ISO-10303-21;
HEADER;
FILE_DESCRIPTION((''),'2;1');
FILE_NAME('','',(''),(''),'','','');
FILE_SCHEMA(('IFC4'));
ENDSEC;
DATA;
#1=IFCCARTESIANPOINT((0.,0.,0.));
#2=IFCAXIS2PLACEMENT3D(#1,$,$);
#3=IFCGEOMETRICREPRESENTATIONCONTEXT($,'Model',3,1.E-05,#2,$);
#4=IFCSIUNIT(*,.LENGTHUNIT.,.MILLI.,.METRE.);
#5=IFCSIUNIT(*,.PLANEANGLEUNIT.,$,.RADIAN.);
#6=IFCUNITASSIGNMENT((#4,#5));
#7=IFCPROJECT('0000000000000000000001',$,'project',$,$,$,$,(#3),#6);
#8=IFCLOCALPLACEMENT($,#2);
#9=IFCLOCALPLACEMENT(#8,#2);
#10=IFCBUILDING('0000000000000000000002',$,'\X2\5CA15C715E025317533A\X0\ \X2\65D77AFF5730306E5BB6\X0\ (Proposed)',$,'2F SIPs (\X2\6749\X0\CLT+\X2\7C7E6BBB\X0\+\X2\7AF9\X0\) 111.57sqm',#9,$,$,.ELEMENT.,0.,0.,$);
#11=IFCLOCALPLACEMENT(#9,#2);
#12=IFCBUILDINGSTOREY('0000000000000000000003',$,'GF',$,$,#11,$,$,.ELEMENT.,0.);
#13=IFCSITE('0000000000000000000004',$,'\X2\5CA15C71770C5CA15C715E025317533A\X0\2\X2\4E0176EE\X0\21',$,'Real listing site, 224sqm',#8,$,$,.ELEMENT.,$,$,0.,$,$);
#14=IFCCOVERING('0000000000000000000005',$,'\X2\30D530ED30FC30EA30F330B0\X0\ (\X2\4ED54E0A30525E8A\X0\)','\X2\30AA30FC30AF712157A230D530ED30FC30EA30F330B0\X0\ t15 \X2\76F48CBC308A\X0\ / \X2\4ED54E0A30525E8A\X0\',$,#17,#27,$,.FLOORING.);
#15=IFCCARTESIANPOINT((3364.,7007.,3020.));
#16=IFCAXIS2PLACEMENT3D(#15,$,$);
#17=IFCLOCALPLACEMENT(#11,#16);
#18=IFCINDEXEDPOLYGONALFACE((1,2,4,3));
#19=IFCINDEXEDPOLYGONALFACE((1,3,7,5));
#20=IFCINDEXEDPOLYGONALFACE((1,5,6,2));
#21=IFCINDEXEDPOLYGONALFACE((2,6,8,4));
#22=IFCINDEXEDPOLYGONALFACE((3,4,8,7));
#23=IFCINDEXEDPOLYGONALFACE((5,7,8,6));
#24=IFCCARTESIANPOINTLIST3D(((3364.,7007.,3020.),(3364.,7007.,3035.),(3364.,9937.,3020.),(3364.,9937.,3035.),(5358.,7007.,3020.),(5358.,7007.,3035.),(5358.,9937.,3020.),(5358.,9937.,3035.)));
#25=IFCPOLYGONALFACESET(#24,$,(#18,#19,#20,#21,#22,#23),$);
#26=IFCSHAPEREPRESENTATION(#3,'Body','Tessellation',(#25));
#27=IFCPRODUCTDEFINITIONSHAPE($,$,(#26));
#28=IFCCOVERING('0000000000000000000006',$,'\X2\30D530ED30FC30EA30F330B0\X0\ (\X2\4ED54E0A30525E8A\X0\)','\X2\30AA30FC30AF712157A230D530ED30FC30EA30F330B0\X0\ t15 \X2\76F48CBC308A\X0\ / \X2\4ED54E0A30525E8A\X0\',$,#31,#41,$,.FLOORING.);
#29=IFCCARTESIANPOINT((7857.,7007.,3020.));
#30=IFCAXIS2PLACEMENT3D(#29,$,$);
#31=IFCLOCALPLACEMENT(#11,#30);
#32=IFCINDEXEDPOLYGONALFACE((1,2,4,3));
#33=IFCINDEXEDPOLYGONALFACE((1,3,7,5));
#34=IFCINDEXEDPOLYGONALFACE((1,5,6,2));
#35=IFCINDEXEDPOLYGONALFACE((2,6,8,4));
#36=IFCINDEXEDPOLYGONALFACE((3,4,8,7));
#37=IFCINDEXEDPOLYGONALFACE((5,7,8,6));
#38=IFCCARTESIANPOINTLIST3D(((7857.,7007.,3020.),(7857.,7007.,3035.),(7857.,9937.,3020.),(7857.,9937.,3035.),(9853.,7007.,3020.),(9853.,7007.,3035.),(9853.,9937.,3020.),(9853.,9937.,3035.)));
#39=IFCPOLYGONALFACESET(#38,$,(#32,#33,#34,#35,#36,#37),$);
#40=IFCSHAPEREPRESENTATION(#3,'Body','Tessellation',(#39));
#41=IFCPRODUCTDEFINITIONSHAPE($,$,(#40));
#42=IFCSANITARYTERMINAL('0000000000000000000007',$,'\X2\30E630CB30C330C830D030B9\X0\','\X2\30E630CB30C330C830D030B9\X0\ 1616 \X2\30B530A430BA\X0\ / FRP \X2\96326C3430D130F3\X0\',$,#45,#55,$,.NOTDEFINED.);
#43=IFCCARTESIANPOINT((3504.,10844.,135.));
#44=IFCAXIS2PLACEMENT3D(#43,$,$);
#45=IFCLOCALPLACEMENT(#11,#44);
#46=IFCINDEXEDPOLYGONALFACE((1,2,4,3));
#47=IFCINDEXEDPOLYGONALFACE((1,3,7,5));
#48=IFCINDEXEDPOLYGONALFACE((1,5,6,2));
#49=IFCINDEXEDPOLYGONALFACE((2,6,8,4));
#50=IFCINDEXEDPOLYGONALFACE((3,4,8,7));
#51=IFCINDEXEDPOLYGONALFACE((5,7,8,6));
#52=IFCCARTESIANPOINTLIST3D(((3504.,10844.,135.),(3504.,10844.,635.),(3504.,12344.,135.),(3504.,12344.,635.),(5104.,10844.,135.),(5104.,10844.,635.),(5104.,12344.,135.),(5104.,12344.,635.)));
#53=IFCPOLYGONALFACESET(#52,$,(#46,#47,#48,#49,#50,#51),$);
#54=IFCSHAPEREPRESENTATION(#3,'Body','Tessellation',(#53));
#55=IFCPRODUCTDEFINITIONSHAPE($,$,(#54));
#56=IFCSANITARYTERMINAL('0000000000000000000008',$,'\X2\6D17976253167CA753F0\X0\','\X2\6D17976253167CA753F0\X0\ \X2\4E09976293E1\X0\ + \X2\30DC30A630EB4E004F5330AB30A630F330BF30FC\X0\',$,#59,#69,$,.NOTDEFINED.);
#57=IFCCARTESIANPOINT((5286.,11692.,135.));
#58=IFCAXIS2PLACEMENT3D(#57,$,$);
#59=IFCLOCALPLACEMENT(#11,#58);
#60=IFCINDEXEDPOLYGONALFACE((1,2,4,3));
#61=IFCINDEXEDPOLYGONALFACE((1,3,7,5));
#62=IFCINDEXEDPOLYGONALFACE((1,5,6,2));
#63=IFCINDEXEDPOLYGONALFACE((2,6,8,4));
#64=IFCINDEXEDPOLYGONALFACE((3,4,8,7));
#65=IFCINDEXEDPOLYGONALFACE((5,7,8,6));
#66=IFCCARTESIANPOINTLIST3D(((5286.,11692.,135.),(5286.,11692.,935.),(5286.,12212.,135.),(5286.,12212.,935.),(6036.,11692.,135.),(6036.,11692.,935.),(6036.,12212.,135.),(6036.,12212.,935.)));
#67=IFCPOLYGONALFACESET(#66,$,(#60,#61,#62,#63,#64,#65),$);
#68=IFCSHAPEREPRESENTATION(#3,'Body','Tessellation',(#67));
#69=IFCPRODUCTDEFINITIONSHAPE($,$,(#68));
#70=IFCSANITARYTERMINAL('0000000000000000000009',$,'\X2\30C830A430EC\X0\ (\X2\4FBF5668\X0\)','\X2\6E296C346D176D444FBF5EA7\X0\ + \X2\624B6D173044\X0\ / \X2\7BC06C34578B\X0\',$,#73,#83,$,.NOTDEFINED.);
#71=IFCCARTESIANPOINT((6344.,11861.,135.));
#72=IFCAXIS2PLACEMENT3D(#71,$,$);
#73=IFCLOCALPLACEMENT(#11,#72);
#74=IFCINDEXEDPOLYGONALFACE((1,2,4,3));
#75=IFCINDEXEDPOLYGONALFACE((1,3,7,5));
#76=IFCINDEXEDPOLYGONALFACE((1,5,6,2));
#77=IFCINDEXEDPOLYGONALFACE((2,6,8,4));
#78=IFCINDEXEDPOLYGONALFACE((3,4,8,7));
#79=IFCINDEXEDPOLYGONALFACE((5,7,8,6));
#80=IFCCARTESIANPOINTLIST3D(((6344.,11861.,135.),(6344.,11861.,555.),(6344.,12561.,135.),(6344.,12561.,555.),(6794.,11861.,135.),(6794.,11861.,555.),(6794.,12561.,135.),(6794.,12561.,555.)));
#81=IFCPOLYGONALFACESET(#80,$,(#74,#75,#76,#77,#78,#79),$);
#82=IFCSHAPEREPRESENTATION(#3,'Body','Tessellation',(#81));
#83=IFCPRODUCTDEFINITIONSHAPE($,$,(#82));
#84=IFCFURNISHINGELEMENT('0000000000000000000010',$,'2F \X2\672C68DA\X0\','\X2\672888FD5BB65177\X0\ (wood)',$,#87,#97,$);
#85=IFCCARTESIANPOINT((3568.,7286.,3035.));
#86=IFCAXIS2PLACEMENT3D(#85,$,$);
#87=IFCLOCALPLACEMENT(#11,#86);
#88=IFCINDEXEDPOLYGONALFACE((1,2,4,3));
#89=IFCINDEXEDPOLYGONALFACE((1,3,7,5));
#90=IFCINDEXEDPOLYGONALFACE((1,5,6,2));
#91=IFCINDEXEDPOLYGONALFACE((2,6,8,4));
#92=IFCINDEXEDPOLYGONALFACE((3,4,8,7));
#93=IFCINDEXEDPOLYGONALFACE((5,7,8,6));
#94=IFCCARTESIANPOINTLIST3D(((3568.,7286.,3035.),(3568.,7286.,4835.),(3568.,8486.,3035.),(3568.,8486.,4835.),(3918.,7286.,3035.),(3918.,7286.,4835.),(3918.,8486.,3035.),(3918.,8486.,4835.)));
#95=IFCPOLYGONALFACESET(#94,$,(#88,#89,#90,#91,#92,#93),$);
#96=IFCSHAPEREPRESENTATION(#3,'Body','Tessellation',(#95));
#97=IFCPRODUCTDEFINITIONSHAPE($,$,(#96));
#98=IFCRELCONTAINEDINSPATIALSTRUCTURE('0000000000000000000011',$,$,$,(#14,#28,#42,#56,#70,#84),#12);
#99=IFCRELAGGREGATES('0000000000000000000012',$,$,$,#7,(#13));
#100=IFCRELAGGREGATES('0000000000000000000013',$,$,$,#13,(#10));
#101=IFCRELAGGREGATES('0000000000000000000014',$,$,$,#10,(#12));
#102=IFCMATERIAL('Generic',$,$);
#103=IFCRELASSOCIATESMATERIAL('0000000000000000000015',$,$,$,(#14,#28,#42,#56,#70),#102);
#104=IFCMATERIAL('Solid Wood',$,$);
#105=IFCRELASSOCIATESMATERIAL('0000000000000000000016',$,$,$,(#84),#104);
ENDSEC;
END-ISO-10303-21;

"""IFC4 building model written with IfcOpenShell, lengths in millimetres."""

from ifc_helpers import new_model, si_unit, frame, frame_2d, origin, place, context, project, spatial, rectangle, extrude, material, element, save


model = new_model("IFC4")

# Units and contexts
model_context = context("Model", 3, precision=1e-05, world=origin())
ifc_project = project(units=[si_unit("LENGTHUNIT", "METRE", prefix="MILLI"), si_unit("PLANEANGLEUNIT", "RADIAN")], contexts=[model_context])

# Site, building, storey
site_placement = place(None, origin())
site = spatial("IfcSite", under=ifc_project, at=site_placement, Name="岡山県岡山市北区2丁目21", ObjectType="Real listing site, 224sqm", CompositionType="ELEMENT", RefElevation=0.0)
building_placement = place(site_placement, origin())
building = spatial("IfcBuilding", under=site, at=building_placement, Name="岡山市北区 旗竿地の家 (Proposed)", ObjectType="2F SIPs (杉CLT+籾殻+竹) 111.57sqm", CompositionType="ELEMENT", ElevationOfRefHeight=0.0, ElevationOfTerrain=0.0)
storey_placement = place(building_placement, origin())
storey = spatial("IfcBuildingStorey", under=building, at=storey_placement, Name="GF", CompositionType="ELEMENT", Elevation=0.0)

# Shared definitions
ifc_material_1 = material(Name="Solid Wood")

# Shared definitions
ifc_material_2 = material(Name="Generic")

# Coverings
covering_1_placement = place(storey_placement, frame((3364.0, 7007.0, 3020.0)))
element("IfcCovering", 1, at=covering_1_placement, inside=storey, material=ifc_material_2, Name="フローリング (仕上げ床)", Description="オーク無垢フローリング t15 直貼り / 仕上げ床", PredefinedType="FLOORING", context=model_context, shape_type="SweptSolid", body=[
    extrude(rectangle(XDim=1994.0, YDim=2930.0, at=frame_2d((997.0, 1465.0))), frame((3364.0, 7007.0, 3020.0)), (0.0, 0.0, 1.0), 15.0),
])
covering_2_placement = place(storey_placement, frame((7857.0, 7007.0, 3020.0)))
element("IfcCovering", 2, at=covering_2_placement, inside=storey, material=ifc_material_2, Name="フローリング (仕上げ床)", Description="オーク無垢フローリング t15 直貼り / 仕上げ床", PredefinedType="FLOORING", context=model_context, shape_type="SweptSolid", body=[
    extrude(rectangle(XDim=1996.0, YDim=2930.0, at=frame_2d((998.0, 1465.0))), frame((7857.0, 7007.0, 3020.0)), (0.0, 0.0, 1.0), 15.0),
])

# Sanitary terminals
sanitary_terminal_1_placement = place(storey_placement, frame((3504.0, 10844.0, 135.0)))
element("IfcSanitaryTerminal", 3, at=sanitary_terminal_1_placement, inside=storey, material=ifc_material_2, Name="ユニットバス", Description="ユニットバス 1616 サイズ / FRP 防水パン", PredefinedType="NOTDEFINED", context=model_context, shape_type="SweptSolid", body=[
    extrude(rectangle(XDim=1600.0, YDim=1500.0, at=frame_2d((800.0, 750.0))), frame((3504.0, 10844.0, 135.0)), (0.0, 0.0, 1.0), 500.0),
])
sanitary_terminal_2_placement = place(storey_placement, frame((5286.0, 11692.0, 135.0)))
element("IfcSanitaryTerminal", 4, at=sanitary_terminal_2_placement, inside=storey, material=ifc_material_2, Name="洗面化粧台", Description="洗面化粧台 三面鏡 + ボウル一体カウンター", PredefinedType="NOTDEFINED", context=model_context, shape_type="SweptSolid", body=[
    extrude(rectangle(XDim=750.0, YDim=520.0, at=frame_2d((375.0, 260.0))), frame((5286.0, 11692.0, 135.0)), (0.0, 0.0, 1.0), 800.0),
])
sanitary_terminal_3_placement = place(storey_placement, frame((6344.0, 11861.0, 135.0)))
element("IfcSanitaryTerminal", 5, at=sanitary_terminal_3_placement, inside=storey, material=ifc_material_2, Name="トイレ (便器)", Description="温水洗浄便座 + 手洗い / 節水型", PredefinedType="NOTDEFINED", context=model_context, shape_type="SweptSolid", body=[
    extrude(rectangle(XDim=450.0, YDim=700.0, at=frame_2d((225.0, 350.0))), frame((6344.0, 11861.0, 135.0)), (0.0, 0.0, 1.0), 420.0),
])

# Furnishing element
furnishing_placement = place(storey_placement, frame((3568.0, 7286.0, 3035.0)))
element("IfcFurnishingElement", 6, at=furnishing_placement, inside=storey, material=ifc_material_1, Name="2F 本棚", Description="木製家具 (wood)", context=model_context, shape_type="SweptSolid", body=[
    extrude(rectangle(XDim=350.0, YDim=1200.0, at=frame_2d((175.0, 600.0))), frame((3568.0, 7286.0, 3035.0)), (0.0, 0.0, 1.0), 1800.0),
])

save(model, "model.ifc")
